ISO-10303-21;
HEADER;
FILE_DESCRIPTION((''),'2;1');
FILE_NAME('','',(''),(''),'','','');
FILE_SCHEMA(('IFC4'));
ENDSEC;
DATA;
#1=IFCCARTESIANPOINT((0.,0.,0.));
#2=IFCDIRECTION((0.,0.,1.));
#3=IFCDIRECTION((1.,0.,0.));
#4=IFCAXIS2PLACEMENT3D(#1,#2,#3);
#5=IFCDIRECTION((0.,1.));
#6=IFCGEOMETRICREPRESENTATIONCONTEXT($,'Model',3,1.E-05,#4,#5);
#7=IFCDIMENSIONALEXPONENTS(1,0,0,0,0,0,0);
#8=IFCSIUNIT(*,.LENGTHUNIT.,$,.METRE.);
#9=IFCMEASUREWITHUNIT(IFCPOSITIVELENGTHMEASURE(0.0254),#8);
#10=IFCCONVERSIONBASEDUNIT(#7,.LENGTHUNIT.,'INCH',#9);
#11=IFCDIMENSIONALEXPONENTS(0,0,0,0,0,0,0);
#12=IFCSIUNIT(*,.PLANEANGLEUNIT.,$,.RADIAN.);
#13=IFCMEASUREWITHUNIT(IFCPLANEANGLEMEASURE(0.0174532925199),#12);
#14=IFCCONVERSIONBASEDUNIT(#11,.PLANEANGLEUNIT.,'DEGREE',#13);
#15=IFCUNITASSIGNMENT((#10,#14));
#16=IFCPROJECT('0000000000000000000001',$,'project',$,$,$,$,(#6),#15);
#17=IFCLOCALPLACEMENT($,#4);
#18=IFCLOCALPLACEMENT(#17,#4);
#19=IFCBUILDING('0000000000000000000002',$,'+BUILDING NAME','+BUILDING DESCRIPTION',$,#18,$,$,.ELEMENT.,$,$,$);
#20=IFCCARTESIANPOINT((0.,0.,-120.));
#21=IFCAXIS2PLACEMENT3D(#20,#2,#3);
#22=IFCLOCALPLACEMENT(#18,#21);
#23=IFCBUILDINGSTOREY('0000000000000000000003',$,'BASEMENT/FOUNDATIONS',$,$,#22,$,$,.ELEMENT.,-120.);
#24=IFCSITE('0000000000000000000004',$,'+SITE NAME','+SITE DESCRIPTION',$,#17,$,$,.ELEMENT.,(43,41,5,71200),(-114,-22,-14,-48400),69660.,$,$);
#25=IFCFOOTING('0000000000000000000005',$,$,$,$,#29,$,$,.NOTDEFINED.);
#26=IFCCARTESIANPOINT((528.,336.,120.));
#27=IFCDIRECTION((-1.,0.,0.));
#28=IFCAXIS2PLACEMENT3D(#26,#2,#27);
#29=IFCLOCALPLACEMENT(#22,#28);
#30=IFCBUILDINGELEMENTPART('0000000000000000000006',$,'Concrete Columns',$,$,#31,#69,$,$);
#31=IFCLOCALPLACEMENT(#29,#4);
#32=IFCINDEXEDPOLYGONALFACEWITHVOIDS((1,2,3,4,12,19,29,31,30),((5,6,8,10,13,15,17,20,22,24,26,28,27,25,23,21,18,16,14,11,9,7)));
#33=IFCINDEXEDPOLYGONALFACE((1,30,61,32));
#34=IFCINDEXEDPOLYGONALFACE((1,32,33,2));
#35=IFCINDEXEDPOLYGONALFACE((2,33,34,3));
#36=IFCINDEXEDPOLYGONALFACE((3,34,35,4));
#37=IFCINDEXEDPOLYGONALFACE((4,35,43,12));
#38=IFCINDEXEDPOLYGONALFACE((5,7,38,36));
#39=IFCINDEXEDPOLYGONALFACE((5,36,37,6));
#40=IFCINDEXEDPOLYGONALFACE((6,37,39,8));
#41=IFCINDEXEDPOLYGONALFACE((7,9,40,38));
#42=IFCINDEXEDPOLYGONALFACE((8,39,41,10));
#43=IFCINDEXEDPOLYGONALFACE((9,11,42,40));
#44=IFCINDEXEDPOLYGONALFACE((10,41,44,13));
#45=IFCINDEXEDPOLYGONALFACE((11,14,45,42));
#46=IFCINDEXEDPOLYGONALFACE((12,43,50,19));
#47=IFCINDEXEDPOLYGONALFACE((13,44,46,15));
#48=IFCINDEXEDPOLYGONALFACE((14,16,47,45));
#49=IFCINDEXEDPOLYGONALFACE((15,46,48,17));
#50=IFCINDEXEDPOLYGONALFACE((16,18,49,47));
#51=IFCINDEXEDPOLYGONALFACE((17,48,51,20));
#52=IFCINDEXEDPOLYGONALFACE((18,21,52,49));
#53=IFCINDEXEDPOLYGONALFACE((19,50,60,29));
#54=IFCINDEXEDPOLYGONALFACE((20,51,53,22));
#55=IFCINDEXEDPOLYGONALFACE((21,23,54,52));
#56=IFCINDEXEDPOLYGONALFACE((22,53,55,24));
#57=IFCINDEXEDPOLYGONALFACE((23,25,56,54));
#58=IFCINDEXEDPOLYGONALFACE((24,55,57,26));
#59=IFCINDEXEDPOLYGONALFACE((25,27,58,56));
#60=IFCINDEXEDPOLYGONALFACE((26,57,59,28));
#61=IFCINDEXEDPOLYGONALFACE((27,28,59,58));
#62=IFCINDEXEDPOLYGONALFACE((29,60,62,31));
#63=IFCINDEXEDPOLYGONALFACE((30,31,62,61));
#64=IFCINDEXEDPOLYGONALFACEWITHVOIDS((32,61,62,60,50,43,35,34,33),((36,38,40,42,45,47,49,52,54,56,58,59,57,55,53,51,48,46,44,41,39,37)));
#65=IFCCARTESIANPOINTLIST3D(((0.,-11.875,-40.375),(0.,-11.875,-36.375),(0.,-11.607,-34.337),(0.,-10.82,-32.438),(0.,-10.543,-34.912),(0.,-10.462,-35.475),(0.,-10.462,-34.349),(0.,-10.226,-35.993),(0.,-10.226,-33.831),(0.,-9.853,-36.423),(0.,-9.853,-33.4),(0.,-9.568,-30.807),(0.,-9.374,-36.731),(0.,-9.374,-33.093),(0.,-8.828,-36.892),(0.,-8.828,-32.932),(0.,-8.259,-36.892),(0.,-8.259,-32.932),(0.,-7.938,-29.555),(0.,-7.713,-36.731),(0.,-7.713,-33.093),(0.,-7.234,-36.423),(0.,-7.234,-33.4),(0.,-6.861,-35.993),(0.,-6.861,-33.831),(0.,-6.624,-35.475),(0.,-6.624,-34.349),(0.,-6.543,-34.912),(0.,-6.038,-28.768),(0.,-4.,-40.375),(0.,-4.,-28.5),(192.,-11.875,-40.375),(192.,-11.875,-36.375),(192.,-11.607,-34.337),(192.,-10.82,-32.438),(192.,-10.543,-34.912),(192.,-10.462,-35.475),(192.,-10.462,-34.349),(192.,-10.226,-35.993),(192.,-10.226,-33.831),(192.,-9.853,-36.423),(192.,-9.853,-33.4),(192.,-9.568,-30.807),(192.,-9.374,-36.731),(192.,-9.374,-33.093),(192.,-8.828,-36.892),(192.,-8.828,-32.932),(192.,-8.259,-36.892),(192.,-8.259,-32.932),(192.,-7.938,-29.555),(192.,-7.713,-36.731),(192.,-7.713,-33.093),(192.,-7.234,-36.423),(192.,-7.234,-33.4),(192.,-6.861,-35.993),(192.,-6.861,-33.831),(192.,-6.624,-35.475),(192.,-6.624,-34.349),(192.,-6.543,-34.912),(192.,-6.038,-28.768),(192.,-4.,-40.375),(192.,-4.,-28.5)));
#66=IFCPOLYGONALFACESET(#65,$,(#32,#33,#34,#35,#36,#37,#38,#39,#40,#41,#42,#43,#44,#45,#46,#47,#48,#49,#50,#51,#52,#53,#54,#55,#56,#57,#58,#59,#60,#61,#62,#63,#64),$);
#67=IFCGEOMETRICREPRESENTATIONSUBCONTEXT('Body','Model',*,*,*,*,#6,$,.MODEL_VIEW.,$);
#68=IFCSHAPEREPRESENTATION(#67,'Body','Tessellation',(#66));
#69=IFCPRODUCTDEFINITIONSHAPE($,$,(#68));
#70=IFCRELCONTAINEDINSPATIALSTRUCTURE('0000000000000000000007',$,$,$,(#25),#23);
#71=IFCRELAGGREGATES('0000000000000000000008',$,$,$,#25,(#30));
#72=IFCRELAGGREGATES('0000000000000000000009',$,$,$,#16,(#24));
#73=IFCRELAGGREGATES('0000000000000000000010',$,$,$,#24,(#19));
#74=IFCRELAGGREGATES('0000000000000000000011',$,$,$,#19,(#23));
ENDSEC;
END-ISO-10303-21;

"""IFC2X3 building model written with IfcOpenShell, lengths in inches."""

from ifc_helpers import new_model, entity, si_unit, converted_unit, point, direction, frame, frame_2d, origin_with_axes, place, context, subcontext, project, spatial, polyline, circle_curve, parameter, trimmed, segment, composite_curve, outline, extrude, element, aggregate, save


model = new_model("IFC2X3")

# Units and contexts
model_context = context("Model", 3, precision=1e-05, world=origin_with_axes(), true_north=direction((0.0, 1.0)))
body_context = subcontext(model_context, "Body", "Model", "MODEL_VIEW")
ifc_project = project(units=[converted_unit("LENGTHUNIT", "INCH", entity("IfcPositiveLengthMeasure", 0.0254), si_unit("LENGTHUNIT", "METRE"), dimensions=[1, 0, 0, 0, 0, 0, 0]), converted_unit("PLANEANGLEUNIT", "DEGREE", entity("IfcPlaneAngleMeasure", 0.0174532925199), si_unit("PLANEANGLEUNIT", "RADIAN"), dimensions=[0, 0, 0, 0, 0, 0, 0])], contexts=[model_context])

# Site, building, storey
site_placement = place(None, origin_with_axes())
site = spatial("IfcSite", under=ifc_project, at=site_placement, Name="+SITE NAME", Description="+SITE DESCRIPTION", CompositionType="ELEMENT", RefLatitude=(43, 41, 5, 71200), RefLongitude=(-114, -22, -14, -48400), RefElevation=69660.0)
building_placement = place(site_placement, origin_with_axes())
building = spatial("IfcBuilding", under=site, at=building_placement, Name="+BUILDING NAME", Description="+BUILDING DESCRIPTION", CompositionType="ELEMENT")
storey_placement = place(building_placement, frame((0.0, 0.0, -120.0), z_axis=(0.0, 0.0, 1.0), x_axis=(1.0, 0.0, 0.0)))
storey = spatial("IfcBuildingStorey", under=building, at=storey_placement, Name="BASEMENT/FOUNDATIONS", CompositionType="ELEMENT", Elevation=-120.0)

# Footing, building element part
footing_1_placement = place(storey_placement, frame((528.0, 336.0, 120.0), z_axis=(0.0, 0.0, 1.0), x_axis=(-1.0, 0.0, 0.0)))
footing_1 = element("IfcFooting", 1, at=footing_1_placement, inside=storey, PredefinedType="NOTDEFINED")
building_element_part_1_placement = place(footing_1_placement, origin_with_axes())
building_element_part_1 = element("IfcBuildingElementPart", 2, at=building_element_part_1_placement, Name="Concrete Columns", context=body_context, shape_type="SweptSolid", body=[
    extrude(outline(composite_curve([segment(trimmed(circle_curve(frame_2d((4.0, -36.375), x_axis=(1.0, 0.0)), 7.875), [point((11.875, -36.375)), parameter(0.0)], [point((4.0, -28.5)), parameter(90.0)], True, "CARTESIAN"), True, "CONTINUOUS"), segment(polyline([(4.0, -28.5), (4.0, -40.375), (11.875, -40.375), (11.875, -36.375)]), True, "CONTINUOUS")], self_intersect=False), holes=[composite_curve([segment(trimmed(circle_curve(frame_2d((8.543, -34.912), x_axis=(-1.0, 0.0)), 2.0), [point((10.543, -34.912)), parameter(180.0)], [point((6.543, -34.912)), parameter(0.0)], False, "CARTESIAN"), True, "CONTINUOUS"), segment(trimmed(circle_curve(frame_2d((8.543, -34.912), x_axis=(1.0, 0.0)), 2.0), [point((6.543, -34.912)), parameter(180.0)], [point((10.543, -34.912)), parameter(0.0)], False, "CARTESIAN"), True, "CONTINUOUS")], self_intersect=False)]), frame((0.0, 0.0, 0.0), z_axis=(-1.0, 0.0, 0.0), x_axis=(0.0, -1.0, 0.0)), (0.0, 0.0, -1.0), 192.0),
])
aggregate(footing_1, [building_element_part_1])

save(model, "model.ifc")
